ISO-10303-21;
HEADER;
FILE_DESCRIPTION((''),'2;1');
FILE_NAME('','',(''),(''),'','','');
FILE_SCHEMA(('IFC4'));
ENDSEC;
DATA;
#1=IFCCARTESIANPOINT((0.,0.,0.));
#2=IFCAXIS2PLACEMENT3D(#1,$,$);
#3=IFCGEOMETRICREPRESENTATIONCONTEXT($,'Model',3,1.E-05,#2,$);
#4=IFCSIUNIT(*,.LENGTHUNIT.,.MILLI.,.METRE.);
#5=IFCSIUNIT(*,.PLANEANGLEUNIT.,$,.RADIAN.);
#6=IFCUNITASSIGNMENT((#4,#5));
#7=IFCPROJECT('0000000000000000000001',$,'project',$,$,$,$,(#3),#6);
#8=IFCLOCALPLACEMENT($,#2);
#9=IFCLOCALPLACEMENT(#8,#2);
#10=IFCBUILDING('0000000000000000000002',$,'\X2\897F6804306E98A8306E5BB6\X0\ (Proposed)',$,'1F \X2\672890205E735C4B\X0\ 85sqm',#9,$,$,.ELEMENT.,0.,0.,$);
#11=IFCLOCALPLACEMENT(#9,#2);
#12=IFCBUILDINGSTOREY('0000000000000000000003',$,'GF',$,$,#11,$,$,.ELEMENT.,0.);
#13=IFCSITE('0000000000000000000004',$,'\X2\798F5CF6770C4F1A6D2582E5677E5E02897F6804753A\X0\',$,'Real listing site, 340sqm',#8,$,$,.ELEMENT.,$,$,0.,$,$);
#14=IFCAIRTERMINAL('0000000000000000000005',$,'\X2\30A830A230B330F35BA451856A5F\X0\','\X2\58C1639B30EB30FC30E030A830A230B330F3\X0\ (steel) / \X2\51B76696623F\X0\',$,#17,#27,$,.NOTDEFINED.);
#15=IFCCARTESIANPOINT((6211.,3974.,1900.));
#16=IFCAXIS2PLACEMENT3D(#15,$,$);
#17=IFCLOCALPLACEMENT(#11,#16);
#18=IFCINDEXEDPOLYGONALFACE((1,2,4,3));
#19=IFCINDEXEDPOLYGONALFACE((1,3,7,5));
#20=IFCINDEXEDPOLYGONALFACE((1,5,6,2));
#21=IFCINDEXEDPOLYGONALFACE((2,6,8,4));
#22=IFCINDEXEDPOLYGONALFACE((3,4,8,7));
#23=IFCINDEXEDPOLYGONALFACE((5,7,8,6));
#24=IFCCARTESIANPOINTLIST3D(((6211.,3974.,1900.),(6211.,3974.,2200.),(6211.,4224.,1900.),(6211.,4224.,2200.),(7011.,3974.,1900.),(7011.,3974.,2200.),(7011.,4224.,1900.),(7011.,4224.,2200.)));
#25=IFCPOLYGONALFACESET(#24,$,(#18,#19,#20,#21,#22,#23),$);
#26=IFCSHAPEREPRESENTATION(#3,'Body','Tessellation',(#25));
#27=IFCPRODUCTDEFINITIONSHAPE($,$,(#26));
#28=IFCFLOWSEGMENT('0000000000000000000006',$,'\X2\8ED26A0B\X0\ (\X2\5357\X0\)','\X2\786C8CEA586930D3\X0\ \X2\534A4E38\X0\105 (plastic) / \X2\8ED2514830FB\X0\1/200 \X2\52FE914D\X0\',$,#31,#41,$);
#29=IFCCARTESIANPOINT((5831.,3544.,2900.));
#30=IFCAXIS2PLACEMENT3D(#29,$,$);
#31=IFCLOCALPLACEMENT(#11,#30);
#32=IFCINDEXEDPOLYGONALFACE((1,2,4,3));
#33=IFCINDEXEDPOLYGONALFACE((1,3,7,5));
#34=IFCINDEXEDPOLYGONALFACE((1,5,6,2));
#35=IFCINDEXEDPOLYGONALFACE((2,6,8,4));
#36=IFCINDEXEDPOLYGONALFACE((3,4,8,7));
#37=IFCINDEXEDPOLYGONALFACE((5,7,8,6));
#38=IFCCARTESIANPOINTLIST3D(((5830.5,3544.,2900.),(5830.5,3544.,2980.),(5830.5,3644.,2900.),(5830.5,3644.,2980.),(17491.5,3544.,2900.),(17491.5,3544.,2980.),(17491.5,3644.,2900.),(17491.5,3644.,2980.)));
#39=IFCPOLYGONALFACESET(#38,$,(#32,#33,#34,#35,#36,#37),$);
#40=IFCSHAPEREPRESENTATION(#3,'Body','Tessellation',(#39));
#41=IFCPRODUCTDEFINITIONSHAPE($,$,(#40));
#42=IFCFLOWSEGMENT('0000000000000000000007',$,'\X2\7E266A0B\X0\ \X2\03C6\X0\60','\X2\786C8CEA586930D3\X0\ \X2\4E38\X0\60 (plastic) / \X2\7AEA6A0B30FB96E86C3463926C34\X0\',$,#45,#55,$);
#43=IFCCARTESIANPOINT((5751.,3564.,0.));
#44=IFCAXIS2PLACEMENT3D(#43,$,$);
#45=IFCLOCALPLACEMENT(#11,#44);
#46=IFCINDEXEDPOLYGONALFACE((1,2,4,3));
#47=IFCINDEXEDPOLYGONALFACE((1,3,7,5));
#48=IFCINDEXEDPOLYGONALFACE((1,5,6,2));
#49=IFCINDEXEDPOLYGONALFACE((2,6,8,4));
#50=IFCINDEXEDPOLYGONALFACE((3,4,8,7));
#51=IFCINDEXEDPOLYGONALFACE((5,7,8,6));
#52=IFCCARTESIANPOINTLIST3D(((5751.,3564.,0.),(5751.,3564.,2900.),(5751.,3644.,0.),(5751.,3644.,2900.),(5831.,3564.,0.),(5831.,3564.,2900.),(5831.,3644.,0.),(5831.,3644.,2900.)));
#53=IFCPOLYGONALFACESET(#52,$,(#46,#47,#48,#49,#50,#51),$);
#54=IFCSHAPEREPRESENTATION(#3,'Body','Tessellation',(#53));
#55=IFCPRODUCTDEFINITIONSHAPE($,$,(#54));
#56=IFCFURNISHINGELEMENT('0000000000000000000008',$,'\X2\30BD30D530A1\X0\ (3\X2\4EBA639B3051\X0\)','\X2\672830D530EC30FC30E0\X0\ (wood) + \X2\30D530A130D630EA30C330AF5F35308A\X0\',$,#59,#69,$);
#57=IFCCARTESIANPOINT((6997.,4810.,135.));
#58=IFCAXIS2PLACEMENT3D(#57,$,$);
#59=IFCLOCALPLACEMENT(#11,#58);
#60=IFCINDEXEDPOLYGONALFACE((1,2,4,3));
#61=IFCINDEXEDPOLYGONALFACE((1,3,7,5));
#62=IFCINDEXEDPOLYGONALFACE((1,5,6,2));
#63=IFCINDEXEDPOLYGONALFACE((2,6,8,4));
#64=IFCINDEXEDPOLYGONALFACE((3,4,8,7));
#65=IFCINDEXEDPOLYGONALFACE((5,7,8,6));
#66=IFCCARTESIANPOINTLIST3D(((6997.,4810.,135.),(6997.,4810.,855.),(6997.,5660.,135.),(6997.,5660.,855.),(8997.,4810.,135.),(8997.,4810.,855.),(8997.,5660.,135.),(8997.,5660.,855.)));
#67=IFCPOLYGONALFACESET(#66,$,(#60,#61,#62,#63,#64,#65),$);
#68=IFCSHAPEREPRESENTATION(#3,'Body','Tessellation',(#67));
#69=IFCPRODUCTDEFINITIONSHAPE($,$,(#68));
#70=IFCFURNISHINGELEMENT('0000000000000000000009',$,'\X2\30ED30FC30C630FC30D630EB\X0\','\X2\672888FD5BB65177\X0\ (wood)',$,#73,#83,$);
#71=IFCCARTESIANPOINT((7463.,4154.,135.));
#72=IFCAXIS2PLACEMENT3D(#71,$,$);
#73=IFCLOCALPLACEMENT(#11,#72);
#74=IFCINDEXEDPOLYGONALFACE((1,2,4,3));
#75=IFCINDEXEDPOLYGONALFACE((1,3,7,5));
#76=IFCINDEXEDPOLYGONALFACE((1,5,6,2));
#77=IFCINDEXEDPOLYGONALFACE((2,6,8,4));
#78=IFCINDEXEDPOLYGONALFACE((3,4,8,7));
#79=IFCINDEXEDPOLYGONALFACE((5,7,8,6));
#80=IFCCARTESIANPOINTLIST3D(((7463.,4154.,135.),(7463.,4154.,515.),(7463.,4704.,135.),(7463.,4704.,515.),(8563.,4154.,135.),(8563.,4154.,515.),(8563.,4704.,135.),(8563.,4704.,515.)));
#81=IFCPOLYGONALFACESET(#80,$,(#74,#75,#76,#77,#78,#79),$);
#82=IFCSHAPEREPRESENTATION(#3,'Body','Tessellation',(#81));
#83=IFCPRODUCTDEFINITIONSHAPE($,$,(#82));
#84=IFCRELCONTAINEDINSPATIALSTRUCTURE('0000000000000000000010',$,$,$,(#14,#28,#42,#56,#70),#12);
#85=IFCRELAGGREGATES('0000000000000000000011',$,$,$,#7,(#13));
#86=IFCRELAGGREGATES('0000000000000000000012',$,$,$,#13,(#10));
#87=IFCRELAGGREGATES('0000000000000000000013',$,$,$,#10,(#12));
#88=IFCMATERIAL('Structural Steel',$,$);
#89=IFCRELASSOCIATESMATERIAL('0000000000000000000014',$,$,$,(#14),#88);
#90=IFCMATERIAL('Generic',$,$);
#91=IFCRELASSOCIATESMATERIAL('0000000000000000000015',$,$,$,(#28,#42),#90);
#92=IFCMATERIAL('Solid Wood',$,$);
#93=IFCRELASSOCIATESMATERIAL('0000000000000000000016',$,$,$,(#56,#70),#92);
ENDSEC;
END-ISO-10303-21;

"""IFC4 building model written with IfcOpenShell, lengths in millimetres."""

from ifc_helpers import new_model, si_unit, frame, frame_2d, origin, place, context, project, spatial, rectangle, extrude, material, element, save


model = new_model("IFC4")

# Units and contexts
model_context = context("Model", 3, precision=1e-05, world=origin())
ifc_project = project(units=[si_unit("LENGTHUNIT", "METRE", prefix="MILLI"), si_unit("PLANEANGLEUNIT", "RADIAN")], contexts=[model_context])

# Site, building, storey
site_placement = place(None, origin())
site = spatial("IfcSite", under=ifc_project, at=site_placement, Name="福島県会津若松市西栄町", ObjectType="Real listing site, 340sqm", CompositionType="ELEMENT", RefElevation=0.0)
building_placement = place(site_placement, origin())
building = spatial("IfcBuilding", under=site, at=building_placement, Name="西栄の風の家 (Proposed)", ObjectType="1F 木造平屋 85sqm", CompositionType="ELEMENT", ElevationOfRefHeight=0.0, ElevationOfTerrain=0.0)
storey_placement = place(building_placement, origin())
storey = spatial("IfcBuildingStorey", under=building, at=storey_placement, Name="GF", CompositionType="ELEMENT", Elevation=0.0)

# Shared definitions
ifc_material_1 = material(Name="Solid Wood")

# Shared definitions
ifc_material_2 = material(Name="Structural Steel")

# Shared definitions
ifc_material_3 = material(Name="Generic")

# Air terminal
air_terminal_placement = place(storey_placement, frame((6211.0, 3974.0, 1900.0)))
element("IfcAirTerminal", 1, at=air_terminal_placement, inside=storey, material=ifc_material_2, Name="エアコン室内機", Description="壁掛ルームエアコン (steel) / 冷暖房", PredefinedType="NOTDEFINED", context=model_context, shape_type="SweptSolid", body=[
    extrude(rectangle(XDim=800.0, YDim=250.0, at=frame_2d((400.0, 125.0))), frame((6211.0, 3974.0, 1900.0)), (0.0, 0.0, 1.0), 300.0),
])

# Flow segments
flow_segment_1_placement = place(storey_placement, frame((5831.0, 3544.0, 2900.0)))
element("IfcFlowSegment", 2, at=flow_segment_1_placement, inside=storey, material=ifc_material_3, Name="軒樋 (南)", Description="硬質塩ビ 半丸105 (plastic) / 軒先・1/200 勾配", context=model_context, shape_type="SweptSolid", body=[
    extrude(rectangle(XDim=11661.0, YDim=100.0, at=frame_2d((5830.0, 50.0))), frame((5831.0, 3544.0, 2900.0)), (0.0, 0.0, 1.0), 80.0),
])
flow_segment_2_placement = place(storey_placement, frame((5751.0, 3564.0, 0.0)))
element("IfcFlowSegment", 3, at=flow_segment_2_placement, inside=storey, material=ifc_material_3, Name="縦樋 φ60", Description="硬質塩ビ 丸60 (plastic) / 竪樋・雨水排水", context=model_context, shape_type="SweptSolid", body=[
    extrude(rectangle(XDim=80.0, YDim=80.0, at=frame_2d((40.0, 40.0))), frame((5751.0, 3564.0, 0.0)), (0.0, 0.0, 1.0), 2900.0),
])

# Furnishing elements
furnishing_1_placement = place(storey_placement, frame((6997.0, 4810.0, 135.0)))
element("IfcFurnishingElement", 4, at=furnishing_1_placement, inside=storey, material=ifc_material_1, Name="ソファ (3人掛け)", Description="木フレーム (wood) + ファブリック張り", context=model_context, shape_type="SweptSolid", body=[
    extrude(rectangle(XDim=2000.0, YDim=850.0, at=frame_2d((1000.0, 425.0))), frame((6997.0, 4810.0, 135.0)), (0.0, 0.0, 1.0), 720.0),
])
furnishing_2_placement = place(storey_placement, frame((7463.0, 4154.0, 135.0)))
element("IfcFurnishingElement", 5, at=furnishing_2_placement, inside=storey, material=ifc_material_1, Name="ローテーブル", Description="木製家具 (wood)", context=model_context, shape_type="SweptSolid", body=[
    extrude(rectangle(XDim=1100.0, YDim=550.0, at=frame_2d((550.0, 275.0))), frame((7463.0, 4154.0, 135.0)), (0.0, 0.0, 1.0), 380.0),
])

save(model, "model.ifc")
